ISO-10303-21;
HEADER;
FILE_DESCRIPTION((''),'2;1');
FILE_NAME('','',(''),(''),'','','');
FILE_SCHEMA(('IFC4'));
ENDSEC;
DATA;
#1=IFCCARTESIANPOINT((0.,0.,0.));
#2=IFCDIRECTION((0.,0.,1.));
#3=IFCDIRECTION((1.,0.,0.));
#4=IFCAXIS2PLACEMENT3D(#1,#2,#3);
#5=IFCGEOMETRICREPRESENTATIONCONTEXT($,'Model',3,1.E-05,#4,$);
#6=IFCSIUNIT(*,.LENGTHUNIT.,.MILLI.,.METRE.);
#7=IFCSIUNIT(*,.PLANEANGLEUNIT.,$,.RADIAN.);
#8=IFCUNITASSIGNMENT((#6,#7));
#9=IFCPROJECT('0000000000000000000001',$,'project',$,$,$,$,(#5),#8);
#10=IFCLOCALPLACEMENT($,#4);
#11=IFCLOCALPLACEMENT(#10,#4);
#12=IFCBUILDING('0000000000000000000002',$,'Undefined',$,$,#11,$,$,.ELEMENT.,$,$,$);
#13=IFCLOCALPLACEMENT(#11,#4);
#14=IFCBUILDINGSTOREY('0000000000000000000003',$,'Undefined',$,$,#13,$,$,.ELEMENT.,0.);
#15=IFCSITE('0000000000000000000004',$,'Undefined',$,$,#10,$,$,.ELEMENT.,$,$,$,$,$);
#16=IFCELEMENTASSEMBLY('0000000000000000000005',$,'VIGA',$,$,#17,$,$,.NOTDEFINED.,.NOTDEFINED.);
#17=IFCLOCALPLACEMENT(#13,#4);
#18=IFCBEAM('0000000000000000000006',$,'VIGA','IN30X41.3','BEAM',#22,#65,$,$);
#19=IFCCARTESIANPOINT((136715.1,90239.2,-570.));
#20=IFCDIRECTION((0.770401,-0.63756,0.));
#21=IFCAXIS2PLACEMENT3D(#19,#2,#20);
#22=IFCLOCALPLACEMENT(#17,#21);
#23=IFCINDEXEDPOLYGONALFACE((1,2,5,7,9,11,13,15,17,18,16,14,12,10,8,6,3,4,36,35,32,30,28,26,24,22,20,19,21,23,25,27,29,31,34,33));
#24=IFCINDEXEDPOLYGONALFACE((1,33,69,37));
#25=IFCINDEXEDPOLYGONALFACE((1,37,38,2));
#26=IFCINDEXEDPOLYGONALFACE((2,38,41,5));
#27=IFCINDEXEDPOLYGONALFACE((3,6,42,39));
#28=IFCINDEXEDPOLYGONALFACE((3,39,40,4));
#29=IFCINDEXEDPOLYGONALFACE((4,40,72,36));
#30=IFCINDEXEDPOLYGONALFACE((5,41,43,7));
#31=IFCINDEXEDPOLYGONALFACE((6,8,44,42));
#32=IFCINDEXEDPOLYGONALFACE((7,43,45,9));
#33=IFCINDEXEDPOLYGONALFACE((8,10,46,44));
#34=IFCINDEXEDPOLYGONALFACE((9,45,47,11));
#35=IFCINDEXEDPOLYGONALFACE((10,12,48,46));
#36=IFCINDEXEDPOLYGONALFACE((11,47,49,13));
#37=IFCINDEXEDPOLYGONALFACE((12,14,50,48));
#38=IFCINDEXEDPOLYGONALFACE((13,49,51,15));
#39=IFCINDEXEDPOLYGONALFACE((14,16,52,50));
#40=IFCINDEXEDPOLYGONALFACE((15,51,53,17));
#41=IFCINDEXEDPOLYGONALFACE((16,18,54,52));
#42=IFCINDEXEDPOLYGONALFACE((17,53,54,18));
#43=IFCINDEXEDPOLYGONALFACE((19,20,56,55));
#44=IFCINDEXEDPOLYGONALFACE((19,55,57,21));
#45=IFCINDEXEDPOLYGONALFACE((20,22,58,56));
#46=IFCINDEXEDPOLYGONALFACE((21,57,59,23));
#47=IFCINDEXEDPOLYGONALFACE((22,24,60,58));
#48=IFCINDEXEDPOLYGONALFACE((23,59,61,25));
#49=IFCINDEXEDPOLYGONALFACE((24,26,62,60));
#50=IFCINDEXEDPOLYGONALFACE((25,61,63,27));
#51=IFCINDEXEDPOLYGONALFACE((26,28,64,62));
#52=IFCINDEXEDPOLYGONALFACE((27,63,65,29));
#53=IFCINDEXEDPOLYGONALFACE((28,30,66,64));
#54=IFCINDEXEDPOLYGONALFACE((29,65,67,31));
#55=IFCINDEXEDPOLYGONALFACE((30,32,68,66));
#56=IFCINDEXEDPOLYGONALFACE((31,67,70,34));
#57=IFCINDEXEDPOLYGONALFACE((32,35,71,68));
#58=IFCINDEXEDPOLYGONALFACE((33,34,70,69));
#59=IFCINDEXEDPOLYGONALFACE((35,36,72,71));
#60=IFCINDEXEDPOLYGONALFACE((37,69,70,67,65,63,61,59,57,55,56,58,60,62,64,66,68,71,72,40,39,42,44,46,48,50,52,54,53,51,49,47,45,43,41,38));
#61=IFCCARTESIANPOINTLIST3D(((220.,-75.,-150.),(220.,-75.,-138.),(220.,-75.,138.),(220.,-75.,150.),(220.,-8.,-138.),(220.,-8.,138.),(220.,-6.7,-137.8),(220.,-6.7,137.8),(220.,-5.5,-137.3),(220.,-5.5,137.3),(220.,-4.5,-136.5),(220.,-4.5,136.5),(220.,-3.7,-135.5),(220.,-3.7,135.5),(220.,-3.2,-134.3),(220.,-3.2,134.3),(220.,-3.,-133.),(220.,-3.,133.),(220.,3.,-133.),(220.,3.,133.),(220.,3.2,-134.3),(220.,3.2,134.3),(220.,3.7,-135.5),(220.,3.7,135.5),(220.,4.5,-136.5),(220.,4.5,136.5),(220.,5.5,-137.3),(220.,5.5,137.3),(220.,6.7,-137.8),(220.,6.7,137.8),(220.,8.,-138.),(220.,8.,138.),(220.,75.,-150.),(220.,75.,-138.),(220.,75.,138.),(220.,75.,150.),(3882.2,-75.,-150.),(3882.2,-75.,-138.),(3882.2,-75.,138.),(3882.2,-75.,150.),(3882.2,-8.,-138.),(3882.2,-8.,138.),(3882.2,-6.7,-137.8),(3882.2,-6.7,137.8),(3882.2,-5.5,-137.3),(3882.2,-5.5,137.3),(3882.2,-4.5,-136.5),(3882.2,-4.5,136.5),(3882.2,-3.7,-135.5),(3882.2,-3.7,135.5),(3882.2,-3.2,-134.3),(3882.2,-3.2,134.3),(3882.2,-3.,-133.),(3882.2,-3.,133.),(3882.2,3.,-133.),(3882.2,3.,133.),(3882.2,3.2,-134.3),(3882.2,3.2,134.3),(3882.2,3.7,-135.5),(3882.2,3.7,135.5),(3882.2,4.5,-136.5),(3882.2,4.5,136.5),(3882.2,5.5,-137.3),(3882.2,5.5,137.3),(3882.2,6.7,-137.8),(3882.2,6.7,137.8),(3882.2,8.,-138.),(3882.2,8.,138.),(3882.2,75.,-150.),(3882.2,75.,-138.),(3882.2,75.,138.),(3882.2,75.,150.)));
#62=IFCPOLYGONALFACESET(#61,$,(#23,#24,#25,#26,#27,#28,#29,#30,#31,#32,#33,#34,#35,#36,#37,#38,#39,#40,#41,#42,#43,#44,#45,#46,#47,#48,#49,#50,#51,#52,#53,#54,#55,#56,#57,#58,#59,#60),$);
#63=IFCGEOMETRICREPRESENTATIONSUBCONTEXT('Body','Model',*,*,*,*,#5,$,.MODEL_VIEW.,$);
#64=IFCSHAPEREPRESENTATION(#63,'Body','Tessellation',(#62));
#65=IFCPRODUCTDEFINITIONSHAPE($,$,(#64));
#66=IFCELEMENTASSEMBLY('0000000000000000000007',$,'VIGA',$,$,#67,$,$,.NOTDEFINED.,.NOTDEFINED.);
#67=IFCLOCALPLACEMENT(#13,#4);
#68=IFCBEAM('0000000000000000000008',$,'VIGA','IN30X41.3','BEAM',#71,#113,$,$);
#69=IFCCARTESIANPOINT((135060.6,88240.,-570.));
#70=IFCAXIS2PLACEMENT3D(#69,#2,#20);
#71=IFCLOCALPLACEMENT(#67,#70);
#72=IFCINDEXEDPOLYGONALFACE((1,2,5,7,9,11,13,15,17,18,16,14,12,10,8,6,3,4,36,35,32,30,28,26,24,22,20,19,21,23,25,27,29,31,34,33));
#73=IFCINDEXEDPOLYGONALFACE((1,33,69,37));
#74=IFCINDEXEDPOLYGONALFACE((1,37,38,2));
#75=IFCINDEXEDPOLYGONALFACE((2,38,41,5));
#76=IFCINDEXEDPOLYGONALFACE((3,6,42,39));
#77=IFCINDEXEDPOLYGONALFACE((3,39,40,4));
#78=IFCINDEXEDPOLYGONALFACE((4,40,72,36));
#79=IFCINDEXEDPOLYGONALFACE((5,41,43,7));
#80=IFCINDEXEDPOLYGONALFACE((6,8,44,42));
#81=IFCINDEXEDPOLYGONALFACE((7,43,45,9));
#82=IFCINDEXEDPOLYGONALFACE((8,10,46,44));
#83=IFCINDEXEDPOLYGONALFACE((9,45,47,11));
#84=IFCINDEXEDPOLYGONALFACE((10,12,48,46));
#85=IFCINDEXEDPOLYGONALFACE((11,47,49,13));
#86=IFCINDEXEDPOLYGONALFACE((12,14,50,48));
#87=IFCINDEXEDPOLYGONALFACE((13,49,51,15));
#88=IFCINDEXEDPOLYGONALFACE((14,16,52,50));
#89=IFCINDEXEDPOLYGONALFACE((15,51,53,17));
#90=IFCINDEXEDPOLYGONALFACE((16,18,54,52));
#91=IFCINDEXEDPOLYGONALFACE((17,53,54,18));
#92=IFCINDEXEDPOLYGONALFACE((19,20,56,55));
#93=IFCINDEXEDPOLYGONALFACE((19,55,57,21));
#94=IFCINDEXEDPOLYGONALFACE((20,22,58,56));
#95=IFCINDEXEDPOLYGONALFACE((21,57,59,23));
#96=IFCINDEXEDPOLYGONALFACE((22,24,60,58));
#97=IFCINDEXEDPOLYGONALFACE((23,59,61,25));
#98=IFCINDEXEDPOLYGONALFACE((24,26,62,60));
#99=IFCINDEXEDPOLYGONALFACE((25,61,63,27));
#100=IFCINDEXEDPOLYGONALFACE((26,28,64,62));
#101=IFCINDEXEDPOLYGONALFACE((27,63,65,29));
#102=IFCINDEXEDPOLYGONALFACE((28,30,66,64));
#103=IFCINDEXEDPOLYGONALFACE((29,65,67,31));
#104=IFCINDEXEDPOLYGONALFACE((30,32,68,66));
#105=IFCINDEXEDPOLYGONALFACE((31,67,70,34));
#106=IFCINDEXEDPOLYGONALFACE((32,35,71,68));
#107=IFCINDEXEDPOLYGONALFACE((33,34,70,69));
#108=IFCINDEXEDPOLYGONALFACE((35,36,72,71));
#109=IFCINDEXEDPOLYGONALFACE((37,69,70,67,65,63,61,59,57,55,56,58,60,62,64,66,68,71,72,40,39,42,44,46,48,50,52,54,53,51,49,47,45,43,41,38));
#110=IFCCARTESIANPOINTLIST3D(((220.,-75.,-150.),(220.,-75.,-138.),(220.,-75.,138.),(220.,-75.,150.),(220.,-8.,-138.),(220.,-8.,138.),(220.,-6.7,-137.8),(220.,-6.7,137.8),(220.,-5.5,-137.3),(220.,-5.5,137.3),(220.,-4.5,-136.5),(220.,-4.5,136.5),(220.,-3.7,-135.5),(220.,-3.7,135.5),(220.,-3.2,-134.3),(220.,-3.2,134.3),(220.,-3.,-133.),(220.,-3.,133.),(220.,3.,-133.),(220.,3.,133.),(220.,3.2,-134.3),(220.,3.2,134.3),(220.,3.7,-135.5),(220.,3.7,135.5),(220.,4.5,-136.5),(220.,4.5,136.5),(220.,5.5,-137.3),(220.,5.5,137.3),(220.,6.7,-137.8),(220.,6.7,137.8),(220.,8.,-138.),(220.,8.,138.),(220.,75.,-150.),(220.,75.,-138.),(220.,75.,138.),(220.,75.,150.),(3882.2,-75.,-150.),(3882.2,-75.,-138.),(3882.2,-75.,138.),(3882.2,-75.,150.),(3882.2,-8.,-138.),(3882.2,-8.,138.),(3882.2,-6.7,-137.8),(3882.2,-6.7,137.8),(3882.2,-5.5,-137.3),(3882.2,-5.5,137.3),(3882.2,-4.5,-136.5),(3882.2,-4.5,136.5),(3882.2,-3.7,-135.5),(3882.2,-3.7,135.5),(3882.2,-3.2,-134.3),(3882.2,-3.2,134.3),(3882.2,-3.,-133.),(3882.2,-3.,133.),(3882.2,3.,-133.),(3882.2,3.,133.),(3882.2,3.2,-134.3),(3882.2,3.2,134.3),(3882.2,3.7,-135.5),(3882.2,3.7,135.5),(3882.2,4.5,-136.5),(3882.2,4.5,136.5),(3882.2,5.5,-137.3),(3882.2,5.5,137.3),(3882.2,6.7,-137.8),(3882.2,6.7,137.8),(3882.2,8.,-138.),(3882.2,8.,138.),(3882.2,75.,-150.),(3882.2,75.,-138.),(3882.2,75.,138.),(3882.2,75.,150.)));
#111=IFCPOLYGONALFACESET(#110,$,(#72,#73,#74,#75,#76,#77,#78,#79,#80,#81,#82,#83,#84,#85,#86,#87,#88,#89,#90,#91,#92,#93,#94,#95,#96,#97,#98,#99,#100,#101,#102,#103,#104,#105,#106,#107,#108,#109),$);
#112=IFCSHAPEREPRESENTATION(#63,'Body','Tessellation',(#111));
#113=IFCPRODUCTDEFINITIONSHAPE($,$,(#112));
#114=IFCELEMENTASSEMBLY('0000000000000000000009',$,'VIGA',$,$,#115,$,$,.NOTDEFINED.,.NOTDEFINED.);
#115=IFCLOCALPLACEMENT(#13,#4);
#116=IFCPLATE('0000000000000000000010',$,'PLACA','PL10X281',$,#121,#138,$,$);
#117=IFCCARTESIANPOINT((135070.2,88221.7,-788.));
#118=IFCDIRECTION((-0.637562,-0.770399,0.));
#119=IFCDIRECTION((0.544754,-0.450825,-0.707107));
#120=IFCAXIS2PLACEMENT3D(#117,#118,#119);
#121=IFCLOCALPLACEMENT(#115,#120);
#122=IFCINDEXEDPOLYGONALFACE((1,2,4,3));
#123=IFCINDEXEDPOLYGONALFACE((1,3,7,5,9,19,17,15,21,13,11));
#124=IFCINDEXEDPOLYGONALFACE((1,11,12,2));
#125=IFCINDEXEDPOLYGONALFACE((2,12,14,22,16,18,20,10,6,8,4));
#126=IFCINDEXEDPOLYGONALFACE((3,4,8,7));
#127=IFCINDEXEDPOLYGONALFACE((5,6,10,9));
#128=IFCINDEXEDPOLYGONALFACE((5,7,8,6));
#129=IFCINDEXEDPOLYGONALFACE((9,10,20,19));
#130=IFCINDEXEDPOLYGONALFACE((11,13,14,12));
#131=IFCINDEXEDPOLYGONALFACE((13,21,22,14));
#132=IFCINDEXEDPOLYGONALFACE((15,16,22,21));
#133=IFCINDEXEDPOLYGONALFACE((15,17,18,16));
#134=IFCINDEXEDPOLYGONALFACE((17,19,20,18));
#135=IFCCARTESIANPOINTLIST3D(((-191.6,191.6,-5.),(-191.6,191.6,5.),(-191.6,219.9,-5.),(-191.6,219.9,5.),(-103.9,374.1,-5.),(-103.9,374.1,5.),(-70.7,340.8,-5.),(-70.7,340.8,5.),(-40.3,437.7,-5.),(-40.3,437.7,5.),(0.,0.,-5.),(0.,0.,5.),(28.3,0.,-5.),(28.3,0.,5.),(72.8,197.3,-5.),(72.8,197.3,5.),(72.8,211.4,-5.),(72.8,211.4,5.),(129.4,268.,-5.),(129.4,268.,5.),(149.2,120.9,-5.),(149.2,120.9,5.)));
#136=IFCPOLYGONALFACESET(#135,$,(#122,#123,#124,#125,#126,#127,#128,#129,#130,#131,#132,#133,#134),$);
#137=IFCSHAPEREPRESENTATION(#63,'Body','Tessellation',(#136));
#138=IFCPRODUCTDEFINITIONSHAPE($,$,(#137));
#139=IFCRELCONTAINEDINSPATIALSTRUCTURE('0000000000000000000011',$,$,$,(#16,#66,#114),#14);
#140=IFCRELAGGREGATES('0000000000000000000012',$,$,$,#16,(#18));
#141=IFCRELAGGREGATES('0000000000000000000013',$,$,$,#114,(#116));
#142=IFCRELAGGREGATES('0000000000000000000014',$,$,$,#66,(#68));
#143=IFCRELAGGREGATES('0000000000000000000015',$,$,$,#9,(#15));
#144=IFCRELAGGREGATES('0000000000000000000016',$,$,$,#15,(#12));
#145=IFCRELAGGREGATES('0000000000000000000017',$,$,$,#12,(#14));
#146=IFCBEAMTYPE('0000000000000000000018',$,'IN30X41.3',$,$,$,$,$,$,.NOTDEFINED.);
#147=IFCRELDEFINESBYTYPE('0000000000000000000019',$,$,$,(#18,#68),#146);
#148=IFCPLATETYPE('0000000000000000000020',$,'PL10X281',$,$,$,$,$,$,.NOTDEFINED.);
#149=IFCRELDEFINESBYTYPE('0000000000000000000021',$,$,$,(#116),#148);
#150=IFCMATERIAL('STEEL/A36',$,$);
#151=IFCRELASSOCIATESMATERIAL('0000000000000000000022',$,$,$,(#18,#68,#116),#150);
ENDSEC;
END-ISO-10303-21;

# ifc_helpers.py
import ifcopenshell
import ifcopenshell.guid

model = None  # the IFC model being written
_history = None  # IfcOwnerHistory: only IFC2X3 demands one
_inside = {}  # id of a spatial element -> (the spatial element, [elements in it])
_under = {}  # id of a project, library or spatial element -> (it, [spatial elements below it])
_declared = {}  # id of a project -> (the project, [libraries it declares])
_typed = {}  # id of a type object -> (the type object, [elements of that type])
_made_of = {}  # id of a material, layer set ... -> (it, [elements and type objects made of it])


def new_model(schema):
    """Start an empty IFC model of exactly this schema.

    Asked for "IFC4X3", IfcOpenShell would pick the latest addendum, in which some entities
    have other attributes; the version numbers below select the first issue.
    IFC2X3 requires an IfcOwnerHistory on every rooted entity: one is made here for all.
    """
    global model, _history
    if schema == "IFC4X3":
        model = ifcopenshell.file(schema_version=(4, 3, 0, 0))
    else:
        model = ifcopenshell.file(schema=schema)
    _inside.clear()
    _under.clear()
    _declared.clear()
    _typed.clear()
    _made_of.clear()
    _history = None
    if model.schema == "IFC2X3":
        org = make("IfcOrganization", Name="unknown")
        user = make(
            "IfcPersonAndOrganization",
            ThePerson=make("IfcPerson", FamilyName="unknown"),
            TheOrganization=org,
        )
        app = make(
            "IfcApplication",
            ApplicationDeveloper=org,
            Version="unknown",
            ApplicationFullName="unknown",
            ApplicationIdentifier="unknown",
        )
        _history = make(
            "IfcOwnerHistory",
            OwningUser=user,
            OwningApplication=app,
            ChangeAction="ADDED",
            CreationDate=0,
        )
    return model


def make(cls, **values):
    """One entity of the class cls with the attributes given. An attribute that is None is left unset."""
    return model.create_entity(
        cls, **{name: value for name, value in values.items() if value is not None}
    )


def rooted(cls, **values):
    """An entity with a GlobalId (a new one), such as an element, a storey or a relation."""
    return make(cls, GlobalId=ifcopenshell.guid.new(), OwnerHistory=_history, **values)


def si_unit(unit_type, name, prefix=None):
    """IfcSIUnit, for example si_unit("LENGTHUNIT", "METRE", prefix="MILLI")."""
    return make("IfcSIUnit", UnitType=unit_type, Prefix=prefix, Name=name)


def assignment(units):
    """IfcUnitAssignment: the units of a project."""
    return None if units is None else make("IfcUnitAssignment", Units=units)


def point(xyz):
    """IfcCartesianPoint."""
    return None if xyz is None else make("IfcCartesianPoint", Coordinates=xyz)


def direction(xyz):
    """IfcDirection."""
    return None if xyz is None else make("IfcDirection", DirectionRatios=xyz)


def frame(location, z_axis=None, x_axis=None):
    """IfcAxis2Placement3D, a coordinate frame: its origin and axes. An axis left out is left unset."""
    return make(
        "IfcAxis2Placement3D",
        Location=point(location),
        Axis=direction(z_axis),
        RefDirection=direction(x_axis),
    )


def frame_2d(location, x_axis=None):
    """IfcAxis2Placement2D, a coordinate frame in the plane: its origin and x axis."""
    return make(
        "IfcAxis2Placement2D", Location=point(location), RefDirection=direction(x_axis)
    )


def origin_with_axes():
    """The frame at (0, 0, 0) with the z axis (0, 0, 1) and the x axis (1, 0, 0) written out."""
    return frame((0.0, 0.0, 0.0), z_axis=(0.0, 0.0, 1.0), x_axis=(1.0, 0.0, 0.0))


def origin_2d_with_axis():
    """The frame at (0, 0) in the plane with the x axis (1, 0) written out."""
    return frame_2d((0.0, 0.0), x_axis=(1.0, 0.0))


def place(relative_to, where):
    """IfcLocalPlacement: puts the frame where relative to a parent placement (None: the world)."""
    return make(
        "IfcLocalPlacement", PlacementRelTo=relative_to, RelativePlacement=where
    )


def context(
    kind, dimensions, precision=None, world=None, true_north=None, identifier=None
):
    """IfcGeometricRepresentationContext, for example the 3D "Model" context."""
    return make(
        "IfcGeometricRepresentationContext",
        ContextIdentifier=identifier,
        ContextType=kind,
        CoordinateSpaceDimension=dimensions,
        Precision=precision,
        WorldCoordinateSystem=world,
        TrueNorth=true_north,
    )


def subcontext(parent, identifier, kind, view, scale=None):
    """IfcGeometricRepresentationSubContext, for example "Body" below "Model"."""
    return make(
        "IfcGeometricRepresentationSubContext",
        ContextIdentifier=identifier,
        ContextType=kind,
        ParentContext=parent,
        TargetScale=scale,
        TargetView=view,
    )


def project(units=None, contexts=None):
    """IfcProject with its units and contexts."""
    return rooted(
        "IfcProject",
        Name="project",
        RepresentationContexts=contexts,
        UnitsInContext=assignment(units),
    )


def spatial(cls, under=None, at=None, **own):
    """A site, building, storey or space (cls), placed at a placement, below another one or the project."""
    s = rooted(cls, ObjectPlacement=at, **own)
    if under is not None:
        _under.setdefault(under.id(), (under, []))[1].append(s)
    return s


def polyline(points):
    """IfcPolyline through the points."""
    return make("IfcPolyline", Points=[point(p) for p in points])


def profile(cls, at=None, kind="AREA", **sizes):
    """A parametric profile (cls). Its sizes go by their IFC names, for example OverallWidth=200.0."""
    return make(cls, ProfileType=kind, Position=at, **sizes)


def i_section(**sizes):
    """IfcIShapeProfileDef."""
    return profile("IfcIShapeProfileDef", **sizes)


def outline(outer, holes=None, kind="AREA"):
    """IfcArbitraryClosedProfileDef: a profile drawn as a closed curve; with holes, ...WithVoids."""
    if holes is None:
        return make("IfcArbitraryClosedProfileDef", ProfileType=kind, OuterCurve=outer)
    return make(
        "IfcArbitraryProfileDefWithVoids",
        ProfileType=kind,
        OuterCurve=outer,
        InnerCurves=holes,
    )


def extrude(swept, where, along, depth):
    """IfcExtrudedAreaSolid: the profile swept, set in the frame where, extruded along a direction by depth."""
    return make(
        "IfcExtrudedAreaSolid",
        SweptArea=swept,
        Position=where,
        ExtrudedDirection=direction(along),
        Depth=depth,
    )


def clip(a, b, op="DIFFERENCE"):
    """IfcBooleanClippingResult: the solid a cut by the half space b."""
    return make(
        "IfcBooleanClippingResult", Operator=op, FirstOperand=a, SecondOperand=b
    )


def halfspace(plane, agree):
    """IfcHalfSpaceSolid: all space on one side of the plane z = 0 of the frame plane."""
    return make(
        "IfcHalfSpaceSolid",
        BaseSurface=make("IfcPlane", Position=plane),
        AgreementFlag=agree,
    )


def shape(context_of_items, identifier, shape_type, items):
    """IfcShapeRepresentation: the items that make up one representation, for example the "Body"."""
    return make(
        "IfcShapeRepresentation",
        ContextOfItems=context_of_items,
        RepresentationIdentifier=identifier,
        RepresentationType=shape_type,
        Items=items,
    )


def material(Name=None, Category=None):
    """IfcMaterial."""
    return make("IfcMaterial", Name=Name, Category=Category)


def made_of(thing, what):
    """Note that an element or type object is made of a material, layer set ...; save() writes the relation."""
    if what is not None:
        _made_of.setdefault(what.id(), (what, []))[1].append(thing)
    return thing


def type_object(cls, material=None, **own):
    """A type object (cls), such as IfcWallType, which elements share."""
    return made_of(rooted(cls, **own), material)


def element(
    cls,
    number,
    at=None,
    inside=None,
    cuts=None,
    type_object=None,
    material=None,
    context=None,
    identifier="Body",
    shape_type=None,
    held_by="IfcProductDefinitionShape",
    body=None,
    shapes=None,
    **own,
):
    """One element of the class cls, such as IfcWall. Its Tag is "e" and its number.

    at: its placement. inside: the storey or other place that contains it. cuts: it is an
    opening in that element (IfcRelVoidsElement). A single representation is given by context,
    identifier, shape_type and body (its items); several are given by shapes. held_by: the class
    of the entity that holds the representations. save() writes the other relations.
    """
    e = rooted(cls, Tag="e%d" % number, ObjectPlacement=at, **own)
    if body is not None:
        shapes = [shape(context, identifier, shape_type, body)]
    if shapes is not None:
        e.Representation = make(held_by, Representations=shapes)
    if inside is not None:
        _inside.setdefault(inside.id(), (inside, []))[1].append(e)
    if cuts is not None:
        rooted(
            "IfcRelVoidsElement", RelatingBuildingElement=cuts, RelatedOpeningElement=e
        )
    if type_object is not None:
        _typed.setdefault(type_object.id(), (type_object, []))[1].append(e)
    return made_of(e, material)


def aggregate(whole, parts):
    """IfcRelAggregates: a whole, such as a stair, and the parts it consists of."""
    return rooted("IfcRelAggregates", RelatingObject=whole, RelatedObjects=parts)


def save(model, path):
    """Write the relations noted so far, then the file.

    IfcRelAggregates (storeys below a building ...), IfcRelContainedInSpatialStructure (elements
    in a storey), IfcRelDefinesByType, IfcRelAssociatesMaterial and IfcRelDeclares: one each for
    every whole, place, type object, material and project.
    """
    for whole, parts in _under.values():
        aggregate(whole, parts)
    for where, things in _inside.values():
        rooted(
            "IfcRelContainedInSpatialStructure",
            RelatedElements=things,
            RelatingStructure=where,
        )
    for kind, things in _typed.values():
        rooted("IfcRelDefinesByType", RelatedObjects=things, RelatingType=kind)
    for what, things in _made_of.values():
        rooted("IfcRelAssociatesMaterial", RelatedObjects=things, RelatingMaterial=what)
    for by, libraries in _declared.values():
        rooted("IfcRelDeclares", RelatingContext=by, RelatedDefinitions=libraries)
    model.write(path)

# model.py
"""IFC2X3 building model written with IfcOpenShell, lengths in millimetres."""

from ifc_helpers import new_model, si_unit, frame, origin_with_axes, origin_2d_with_axis, place, context, subcontext, project, spatial, polyline, i_section, outline, extrude, clip, halfspace, material, type_object, element, aggregate, save


model = new_model("IFC2X3")

# Units and contexts
model_context = context("Model", 3, precision=1e-05, world=origin_with_axes())
body_context = subcontext(model_context, "Body", "Model", "MODEL_VIEW")
ifc_project = project(units=[si_unit("LENGTHUNIT", "METRE", prefix="MILLI"), si_unit("PLANEANGLEUNIT", "RADIAN")], contexts=[model_context])

# Site, building, storey
site_placement = place(None, origin_with_axes())
site = spatial("IfcSite", under=ifc_project, at=site_placement, Name="Undefined", CompositionType="ELEMENT")
building_placement = place(site_placement, origin_with_axes())
building = spatial("IfcBuilding", under=site, at=building_placement, Name="Undefined", CompositionType="ELEMENT")
storey_placement = place(building_placement, origin_with_axes())
storey = spatial("IfcBuildingStorey", under=building, at=storey_placement, Name="Undefined", CompositionType="ELEMENT", Elevation=0.0)

# Shared definitions
ifc_material_1 = material(Name="STEEL/A36")

# Element assemblies, beams
assembly_1_placement = place(storey_placement, origin_with_axes())
assembly_1 = element("IfcElementAssembly", 1, at=assembly_1_placement, inside=storey, Name="VIGA", AssemblyPlace="NOTDEFINED", PredefinedType="NOTDEFINED")
beam_type_1 = type_object("IfcBeamType", Name="IN30X41.3", PredefinedType="NOTDEFINED")
beam_1_placement = place(assembly_1_placement, frame((136715.1, 90239.2, -570.0), z_axis=(0.0, 0.0, 1.0), x_axis=(0.770401, -0.63756, 0.0)))
beam_1 = element("IfcBeam", 2, at=beam_1_placement, type_object=beam_type_1, material=ifc_material_1, Name="VIGA", Description="IN30X41.3", ObjectType="BEAM", context=body_context, shape_type="Clipping", body=[
    clip(extrude(i_section(OverallWidth=150.0, OverallDepth=300.0, WebThickness=6.0, FlangeThickness=12.0, FilletRadius=5.0, at=origin_2d_with_axis()), frame((3882.2, 0.0, 0.0), z_axis=(-1.0, 0.0, 0.0), x_axis=(0.0, -1.0, 0.0)), (0.0, 0.0, 1.0), 3882.2), halfspace(frame((220.0, 0.0, 250.0), z_axis=(-1.0, 0.000003, 0.0), x_axis=(-0.000003, -1.0, 0.0)), False)),
])
aggregate(assembly_1, [beam_1])
assembly_2_placement = place(storey_placement, origin_with_axes())
assembly_2 = element("IfcElementAssembly", 3, at=assembly_2_placement, inside=storey, Name="VIGA", AssemblyPlace="NOTDEFINED", PredefinedType="NOTDEFINED")
beam_2_placement = place(assembly_2_placement, frame((135060.6, 88240.0, -570.0), z_axis=(0.0, 0.0, 1.0), x_axis=(0.770401, -0.63756, 0.0)))
beam_2 = element("IfcBeam", 4, at=beam_2_placement, type_object=beam_type_1, material=ifc_material_1, Name="VIGA", Description="IN30X41.3", ObjectType="BEAM", context=body_context, shape_type="Clipping", body=[
    clip(extrude(i_section(OverallWidth=150.0, OverallDepth=300.0, WebThickness=6.0, FlangeThickness=12.0, FilletRadius=5.0, at=origin_2d_with_axis()), frame((3882.2, 0.0, 0.0), z_axis=(-1.0, 0.0, 0.0), x_axis=(0.0, -1.0, 0.0)), (0.0, 0.0, 1.0), 3882.2), halfspace(frame((220.0, 0.0, 250.0), z_axis=(-1.0, 0.000003, 0.0), x_axis=(-0.000003, -1.0, 0.0)), False)),
])

# Element assembly
assembly_3_placement = place(storey_placement, origin_with_axes())
assembly_3 = element("IfcElementAssembly", 5, at=assembly_3_placement, inside=storey, Name="VIGA", AssemblyPlace="NOTDEFINED", PredefinedType="NOTDEFINED")

# Plate
plate_type_1 = type_object("IfcPlateType", Name="PL10X281", PredefinedType="NOTDEFINED")
plate_1_placement = place(assembly_3_placement, frame((135070.2, 88221.7, -788.0), z_axis=(-0.637562, -0.770399, 0.0), x_axis=(0.544754, -0.450825, -0.707107)))
plate_1 = element("IfcPlate", 6, at=plate_1_placement, type_object=plate_type_1, material=ifc_material_1, Name="PLACA", Description="PL10X281", context=body_context, shape_type="SweptSolid", body=[
    extrude(outline(polyline([(0.0, 0.0), (28.3, 0.0), (149.2, 120.9), (72.8, 197.3), (72.8, 211.4), (129.4, 268.0), (-40.3, 437.7), (-103.9, 374.1), (-70.7, 340.8), (-191.6, 219.9), (-191.6, 191.6), (0.0, 0.0)])), frame((0.0, 0.0, -5.0), z_axis=(0.0, 0.0, 1.0), x_axis=(1.0, 0.0, 0.0)), (0.0, 0.0, 1.0), 10.0),
])
aggregate(assembly_3, [plate_1])

aggregate(assembly_2, [beam_2])

save(model, "model.ifc")
